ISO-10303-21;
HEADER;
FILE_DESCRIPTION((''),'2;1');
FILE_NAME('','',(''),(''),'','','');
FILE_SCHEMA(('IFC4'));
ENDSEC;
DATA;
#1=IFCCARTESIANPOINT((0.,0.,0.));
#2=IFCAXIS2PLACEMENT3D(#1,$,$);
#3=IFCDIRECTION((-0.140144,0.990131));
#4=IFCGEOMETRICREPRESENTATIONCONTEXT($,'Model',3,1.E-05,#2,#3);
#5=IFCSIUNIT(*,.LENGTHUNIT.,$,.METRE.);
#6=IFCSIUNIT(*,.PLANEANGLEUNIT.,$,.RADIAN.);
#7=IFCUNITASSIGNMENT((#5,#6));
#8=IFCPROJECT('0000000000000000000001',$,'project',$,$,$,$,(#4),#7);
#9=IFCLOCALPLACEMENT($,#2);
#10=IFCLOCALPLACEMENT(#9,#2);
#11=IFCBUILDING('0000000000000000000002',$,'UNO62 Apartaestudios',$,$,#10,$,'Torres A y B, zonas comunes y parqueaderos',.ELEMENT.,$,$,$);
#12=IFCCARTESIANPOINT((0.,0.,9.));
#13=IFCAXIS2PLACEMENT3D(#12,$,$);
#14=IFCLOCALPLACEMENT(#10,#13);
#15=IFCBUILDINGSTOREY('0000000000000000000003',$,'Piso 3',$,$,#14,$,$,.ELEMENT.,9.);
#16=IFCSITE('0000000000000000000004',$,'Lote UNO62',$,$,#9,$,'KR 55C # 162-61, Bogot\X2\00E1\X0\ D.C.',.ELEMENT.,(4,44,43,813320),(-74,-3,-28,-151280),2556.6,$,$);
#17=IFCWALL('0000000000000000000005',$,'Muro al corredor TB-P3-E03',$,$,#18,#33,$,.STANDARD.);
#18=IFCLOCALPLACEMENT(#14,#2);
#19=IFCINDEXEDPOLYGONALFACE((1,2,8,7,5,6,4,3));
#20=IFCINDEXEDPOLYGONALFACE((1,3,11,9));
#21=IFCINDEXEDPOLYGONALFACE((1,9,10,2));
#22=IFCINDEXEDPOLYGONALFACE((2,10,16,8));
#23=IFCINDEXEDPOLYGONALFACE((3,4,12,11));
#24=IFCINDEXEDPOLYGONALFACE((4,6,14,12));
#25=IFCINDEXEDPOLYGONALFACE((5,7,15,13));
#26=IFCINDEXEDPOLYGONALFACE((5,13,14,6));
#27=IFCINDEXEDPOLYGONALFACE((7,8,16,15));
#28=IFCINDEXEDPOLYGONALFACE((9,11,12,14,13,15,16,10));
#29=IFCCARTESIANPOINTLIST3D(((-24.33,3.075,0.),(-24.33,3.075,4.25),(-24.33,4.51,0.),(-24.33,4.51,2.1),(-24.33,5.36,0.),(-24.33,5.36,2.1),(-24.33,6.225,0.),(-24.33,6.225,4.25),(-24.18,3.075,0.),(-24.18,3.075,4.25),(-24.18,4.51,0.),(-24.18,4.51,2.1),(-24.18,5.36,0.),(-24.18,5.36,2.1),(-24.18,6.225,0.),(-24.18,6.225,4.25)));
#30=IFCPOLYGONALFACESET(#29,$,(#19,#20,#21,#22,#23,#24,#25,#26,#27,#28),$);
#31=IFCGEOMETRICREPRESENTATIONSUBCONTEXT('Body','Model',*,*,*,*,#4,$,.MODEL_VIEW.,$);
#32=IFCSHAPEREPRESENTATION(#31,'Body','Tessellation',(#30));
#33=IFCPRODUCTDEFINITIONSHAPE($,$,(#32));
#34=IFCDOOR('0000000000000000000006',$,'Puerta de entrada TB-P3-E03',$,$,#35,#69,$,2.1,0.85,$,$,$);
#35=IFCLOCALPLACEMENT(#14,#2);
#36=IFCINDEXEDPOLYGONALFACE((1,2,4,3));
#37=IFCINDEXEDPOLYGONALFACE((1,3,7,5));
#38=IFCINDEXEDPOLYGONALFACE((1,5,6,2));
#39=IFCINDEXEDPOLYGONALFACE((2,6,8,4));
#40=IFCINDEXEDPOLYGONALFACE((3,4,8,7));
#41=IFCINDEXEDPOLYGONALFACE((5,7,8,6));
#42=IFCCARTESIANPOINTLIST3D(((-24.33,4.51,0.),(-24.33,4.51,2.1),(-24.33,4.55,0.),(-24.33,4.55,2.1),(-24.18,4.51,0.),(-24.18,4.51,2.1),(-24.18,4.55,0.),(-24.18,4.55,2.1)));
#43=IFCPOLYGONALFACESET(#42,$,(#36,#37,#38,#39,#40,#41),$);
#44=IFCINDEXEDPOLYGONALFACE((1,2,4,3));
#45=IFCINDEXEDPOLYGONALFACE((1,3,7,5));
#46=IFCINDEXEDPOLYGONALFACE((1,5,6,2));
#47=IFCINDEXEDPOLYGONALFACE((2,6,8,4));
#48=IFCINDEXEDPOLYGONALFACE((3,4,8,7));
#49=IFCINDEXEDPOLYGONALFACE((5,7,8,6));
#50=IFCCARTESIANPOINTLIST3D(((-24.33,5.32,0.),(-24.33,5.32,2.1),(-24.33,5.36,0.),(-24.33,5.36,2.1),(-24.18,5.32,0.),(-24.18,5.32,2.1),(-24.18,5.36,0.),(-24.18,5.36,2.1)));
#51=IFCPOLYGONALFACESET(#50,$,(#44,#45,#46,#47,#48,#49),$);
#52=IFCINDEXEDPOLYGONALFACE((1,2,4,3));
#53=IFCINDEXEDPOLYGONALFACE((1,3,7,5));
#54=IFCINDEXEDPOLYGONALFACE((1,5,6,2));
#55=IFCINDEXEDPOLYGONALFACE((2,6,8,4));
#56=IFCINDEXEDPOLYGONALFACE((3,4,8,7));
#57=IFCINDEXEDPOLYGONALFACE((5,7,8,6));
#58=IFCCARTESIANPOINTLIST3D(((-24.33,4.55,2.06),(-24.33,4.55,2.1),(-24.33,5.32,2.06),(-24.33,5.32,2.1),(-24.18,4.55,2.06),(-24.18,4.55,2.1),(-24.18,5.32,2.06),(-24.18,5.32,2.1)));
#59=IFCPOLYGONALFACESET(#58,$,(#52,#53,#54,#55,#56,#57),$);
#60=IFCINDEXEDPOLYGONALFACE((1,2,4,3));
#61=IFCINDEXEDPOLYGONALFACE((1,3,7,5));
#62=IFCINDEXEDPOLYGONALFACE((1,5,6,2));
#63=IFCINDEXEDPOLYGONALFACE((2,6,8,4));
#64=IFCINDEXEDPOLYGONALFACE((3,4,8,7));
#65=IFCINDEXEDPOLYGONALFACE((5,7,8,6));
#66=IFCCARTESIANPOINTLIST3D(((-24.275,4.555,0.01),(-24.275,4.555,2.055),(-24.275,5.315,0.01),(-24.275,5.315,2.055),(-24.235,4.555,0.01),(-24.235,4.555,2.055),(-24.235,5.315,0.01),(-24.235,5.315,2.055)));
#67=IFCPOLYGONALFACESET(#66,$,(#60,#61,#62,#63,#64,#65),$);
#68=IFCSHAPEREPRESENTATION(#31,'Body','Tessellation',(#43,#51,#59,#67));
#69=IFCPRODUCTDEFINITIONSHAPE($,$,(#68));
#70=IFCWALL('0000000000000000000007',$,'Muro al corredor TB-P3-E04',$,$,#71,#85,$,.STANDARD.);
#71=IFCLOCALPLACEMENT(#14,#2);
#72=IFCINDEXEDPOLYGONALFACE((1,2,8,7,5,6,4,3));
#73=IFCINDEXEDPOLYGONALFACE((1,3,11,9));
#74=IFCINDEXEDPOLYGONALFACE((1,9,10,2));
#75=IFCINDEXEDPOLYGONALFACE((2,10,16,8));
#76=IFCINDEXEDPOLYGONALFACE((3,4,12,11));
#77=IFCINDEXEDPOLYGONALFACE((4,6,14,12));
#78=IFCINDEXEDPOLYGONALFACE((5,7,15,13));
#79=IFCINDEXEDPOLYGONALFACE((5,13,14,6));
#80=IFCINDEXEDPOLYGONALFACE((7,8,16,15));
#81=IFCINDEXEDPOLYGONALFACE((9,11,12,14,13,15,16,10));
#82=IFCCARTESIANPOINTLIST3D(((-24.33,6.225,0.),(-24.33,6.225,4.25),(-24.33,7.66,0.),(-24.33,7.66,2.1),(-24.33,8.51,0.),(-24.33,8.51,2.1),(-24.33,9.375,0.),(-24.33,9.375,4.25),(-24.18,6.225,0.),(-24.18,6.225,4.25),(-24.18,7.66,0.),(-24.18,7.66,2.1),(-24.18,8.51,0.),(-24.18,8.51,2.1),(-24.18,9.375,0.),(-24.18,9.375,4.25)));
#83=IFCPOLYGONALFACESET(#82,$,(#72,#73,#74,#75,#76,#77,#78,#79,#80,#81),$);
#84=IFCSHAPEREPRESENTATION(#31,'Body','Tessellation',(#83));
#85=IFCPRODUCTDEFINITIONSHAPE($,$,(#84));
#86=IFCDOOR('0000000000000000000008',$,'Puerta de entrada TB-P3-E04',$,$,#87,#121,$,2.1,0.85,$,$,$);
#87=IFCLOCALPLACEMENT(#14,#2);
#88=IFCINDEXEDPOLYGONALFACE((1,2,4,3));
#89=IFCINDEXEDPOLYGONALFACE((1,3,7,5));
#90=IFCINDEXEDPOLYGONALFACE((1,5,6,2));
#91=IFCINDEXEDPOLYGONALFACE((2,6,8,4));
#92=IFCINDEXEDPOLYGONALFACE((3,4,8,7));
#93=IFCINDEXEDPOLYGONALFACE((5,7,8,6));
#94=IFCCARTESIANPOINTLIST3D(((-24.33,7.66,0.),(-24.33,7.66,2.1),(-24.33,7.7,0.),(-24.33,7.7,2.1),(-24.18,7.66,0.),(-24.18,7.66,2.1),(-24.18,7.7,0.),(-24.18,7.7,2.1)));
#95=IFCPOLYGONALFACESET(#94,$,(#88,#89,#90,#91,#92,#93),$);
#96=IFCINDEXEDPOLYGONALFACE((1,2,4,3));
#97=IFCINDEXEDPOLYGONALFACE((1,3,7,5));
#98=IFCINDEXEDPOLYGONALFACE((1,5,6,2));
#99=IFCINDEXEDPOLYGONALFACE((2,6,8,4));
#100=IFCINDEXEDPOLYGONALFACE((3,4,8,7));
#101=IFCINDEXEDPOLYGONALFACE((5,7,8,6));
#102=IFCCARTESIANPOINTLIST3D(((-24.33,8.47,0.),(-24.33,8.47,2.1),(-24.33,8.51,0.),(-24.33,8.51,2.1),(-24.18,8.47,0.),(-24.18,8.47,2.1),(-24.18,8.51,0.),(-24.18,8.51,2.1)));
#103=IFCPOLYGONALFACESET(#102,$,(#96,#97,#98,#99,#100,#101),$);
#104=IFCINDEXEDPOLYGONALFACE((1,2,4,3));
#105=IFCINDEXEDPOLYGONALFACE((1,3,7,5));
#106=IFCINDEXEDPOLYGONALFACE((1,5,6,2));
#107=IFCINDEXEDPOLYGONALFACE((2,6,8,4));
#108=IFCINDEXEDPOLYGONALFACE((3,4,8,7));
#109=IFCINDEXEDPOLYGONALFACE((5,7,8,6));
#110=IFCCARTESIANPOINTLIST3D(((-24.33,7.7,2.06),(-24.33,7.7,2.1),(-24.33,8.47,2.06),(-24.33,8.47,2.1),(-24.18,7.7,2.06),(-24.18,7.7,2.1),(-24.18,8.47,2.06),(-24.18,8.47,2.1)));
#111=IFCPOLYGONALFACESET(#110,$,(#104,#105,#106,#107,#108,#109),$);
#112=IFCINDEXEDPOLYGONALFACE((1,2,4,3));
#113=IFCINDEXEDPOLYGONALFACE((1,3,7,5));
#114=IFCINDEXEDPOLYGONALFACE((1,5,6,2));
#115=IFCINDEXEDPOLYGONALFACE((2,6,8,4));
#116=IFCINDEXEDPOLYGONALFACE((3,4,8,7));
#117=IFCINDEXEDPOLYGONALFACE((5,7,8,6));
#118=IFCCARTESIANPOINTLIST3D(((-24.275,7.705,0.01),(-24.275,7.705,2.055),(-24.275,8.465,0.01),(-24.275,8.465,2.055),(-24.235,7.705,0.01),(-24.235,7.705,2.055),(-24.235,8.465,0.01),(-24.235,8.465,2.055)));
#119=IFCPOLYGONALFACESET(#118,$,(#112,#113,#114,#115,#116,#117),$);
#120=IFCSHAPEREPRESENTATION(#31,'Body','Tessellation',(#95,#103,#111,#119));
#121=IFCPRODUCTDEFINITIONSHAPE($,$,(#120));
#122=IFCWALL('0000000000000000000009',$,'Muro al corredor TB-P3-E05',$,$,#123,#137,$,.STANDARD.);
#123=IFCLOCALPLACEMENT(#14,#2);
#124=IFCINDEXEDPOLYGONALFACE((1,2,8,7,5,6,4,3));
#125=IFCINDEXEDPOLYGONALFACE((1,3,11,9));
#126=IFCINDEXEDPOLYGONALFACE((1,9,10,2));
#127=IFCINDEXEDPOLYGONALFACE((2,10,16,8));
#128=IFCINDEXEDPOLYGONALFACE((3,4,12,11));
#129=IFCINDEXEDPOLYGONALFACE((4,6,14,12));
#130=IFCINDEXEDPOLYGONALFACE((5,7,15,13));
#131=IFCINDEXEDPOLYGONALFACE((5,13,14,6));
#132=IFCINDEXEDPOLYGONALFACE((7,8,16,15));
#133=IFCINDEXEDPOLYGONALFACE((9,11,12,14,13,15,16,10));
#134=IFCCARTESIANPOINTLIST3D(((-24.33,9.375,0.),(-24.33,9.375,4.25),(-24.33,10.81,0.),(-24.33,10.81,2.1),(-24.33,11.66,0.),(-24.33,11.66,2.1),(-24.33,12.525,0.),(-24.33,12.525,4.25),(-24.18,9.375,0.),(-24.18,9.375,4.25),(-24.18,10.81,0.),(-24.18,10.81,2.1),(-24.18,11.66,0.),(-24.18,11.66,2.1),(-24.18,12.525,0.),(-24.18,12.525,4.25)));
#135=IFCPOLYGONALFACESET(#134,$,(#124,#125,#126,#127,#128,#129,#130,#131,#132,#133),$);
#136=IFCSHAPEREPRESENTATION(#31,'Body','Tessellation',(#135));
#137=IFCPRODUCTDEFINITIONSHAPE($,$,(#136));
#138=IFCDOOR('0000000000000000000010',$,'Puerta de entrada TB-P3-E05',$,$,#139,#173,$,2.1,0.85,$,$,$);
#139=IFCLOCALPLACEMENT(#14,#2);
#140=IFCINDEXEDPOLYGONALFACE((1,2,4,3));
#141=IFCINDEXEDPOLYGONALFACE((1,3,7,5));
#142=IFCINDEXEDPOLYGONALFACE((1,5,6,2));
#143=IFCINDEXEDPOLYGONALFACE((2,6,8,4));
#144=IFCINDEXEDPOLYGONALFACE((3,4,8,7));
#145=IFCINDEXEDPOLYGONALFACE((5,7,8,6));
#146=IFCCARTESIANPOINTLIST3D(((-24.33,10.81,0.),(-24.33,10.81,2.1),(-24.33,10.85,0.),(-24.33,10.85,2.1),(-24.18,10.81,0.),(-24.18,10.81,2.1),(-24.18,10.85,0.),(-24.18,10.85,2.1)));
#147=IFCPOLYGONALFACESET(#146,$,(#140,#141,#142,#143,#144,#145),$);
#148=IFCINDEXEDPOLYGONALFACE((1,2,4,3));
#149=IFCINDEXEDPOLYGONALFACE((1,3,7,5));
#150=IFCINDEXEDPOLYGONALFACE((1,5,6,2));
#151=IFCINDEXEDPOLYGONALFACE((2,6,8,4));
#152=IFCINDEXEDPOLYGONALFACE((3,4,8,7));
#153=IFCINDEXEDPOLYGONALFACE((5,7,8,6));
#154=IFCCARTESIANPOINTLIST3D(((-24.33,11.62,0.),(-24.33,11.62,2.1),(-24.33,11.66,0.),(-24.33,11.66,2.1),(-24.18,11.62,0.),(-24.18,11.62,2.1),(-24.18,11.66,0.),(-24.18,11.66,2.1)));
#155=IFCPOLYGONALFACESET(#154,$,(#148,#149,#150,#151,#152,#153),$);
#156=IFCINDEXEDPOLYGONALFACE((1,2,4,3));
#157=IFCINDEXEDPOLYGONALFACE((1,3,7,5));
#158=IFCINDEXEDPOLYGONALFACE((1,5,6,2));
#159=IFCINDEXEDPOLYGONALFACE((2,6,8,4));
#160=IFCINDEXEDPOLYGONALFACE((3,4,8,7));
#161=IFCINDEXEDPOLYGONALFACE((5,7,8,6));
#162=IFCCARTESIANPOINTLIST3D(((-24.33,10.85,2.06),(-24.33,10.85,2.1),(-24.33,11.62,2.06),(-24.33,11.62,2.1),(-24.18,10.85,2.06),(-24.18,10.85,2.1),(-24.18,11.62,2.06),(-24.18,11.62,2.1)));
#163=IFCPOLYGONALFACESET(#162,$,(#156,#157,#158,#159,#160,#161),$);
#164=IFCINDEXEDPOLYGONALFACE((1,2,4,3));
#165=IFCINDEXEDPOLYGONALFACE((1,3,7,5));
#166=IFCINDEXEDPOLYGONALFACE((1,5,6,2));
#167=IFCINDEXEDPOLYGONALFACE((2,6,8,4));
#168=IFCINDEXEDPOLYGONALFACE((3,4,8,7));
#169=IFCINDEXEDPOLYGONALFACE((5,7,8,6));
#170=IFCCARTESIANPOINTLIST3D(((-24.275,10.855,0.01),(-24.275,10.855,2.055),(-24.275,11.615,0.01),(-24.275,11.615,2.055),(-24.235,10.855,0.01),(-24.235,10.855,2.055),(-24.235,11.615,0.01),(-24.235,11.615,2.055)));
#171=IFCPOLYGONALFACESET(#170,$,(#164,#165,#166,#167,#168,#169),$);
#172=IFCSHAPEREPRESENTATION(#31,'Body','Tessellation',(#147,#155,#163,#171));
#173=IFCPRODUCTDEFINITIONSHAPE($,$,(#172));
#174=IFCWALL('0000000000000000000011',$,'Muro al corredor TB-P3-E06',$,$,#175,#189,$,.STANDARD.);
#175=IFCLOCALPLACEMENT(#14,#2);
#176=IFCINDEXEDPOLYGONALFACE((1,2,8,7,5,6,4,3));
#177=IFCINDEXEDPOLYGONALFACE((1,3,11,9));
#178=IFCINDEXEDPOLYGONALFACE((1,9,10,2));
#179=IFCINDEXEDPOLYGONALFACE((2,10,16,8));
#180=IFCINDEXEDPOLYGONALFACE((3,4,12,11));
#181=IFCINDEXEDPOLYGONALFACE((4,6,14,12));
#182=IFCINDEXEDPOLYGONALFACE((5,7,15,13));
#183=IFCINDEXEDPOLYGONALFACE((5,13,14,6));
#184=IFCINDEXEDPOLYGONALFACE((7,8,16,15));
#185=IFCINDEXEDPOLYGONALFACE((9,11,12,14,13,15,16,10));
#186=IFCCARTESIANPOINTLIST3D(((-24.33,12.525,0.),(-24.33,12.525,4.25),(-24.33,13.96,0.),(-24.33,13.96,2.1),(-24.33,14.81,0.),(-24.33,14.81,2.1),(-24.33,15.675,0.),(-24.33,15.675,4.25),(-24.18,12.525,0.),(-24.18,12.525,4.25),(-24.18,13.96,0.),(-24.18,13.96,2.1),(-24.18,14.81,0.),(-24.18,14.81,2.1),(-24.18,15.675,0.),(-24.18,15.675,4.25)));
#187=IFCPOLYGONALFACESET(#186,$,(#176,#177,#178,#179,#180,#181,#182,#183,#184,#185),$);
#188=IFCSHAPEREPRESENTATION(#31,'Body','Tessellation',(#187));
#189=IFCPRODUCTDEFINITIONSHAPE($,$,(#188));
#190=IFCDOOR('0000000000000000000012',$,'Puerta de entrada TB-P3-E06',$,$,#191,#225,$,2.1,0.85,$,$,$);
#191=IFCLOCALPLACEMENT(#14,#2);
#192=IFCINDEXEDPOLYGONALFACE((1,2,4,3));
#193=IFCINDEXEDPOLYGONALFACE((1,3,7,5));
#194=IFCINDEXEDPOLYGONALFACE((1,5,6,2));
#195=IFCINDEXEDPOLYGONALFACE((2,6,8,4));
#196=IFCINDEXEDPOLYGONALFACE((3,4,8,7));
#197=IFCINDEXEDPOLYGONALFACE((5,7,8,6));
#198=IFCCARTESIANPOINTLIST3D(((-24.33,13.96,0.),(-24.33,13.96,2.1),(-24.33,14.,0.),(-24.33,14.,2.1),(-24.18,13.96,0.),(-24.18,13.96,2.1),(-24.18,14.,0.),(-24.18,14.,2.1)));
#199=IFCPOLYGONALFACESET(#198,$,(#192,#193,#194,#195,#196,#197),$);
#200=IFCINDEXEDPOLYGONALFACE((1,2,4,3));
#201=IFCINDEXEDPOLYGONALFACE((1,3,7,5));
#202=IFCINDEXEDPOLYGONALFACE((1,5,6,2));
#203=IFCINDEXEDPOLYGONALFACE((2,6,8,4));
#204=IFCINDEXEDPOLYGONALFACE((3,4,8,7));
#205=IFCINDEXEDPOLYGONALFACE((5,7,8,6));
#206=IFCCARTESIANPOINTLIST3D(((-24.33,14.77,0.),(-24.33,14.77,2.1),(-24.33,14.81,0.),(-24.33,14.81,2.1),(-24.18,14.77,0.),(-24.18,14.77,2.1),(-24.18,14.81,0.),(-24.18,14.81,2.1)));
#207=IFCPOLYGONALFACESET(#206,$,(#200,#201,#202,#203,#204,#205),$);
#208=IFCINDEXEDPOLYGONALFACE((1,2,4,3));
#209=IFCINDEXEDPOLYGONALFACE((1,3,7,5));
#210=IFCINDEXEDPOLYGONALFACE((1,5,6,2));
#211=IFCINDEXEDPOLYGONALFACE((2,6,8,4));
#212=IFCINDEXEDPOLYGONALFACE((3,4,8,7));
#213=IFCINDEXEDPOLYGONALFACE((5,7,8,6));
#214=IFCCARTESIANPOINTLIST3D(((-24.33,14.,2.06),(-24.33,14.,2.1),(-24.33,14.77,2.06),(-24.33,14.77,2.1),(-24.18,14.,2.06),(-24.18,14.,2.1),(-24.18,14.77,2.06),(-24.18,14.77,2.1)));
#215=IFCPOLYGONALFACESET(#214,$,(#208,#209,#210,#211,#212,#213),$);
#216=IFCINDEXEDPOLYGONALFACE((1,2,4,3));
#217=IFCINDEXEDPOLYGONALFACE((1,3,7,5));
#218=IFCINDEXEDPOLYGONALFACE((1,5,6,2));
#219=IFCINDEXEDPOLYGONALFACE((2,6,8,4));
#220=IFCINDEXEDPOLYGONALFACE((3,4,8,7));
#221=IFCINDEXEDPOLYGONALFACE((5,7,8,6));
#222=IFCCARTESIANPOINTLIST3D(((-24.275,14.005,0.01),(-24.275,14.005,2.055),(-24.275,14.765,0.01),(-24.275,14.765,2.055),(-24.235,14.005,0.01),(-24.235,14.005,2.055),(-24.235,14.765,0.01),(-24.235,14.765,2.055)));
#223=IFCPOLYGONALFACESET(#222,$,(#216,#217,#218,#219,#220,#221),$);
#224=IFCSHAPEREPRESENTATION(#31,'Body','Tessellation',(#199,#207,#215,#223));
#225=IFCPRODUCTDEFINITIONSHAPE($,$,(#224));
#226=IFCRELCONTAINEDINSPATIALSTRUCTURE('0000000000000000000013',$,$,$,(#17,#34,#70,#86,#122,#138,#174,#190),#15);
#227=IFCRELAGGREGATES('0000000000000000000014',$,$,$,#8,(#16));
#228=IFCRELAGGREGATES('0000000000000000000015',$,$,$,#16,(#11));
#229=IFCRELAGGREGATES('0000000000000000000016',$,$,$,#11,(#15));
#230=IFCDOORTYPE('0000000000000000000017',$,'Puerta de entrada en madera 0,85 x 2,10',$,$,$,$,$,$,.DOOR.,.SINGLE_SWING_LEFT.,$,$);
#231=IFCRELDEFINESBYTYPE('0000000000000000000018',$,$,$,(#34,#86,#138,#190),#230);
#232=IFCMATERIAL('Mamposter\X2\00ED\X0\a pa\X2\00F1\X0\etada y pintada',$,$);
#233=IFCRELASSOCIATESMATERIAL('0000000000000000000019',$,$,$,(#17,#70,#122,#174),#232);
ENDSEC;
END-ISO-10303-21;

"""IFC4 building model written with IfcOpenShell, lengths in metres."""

from ifc_helpers import new_model, si_unit, direction, frame, frame_2d, origin, place, context, subcontext, project, spatial, rectangle, extrude, source, transform, mapped, material, type_object, type_shapes, element, fill, save


model = new_model("IFC4")

# Units and contexts
model_context = context("Model", 3, precision=1e-05, world=origin(), true_north=direction((-0.140144, 0.990131)))
body_context = subcontext(model_context, "Body", "Model", "MODEL_VIEW")
ifc_project = project(units=[si_unit("LENGTHUNIT", "METRE"), si_unit("PLANEANGLEUNIT", "RADIAN")], contexts=[model_context])

# Site, building, storey
site_placement = place(None, origin())
site = spatial("IfcSite", under=ifc_project, at=site_placement, Name="Lote UNO62", LongName="KR 55C # 162-61, Bogotá D.C.", CompositionType="ELEMENT", RefLatitude=(4, 44, 43, 813320), RefLongitude=(-74, -3, -28, -151280), RefElevation=2556.6)
building_placement = place(site_placement, origin())
building = spatial("IfcBuilding", under=site, at=building_placement, Name="UNO62 Apartaestudios", LongName="Torres A y B, zonas comunes y parqueaderos", CompositionType="ELEMENT")
storey_placement = place(building_placement, frame((0.0, 0.0, 9.0)))
storey = spatial("IfcBuildingStorey", under=building, at=storey_placement, Name="Piso 3", CompositionType="ELEMENT", Elevation=9.0)

# Shared definitions
placement_1 = place(storey_placement, frame((-24.18, 3.15, 0.0)))
placement_2 = place(storey_placement, frame((-24.18, 6.3, 0.0)))
placement_3 = place(storey_placement, frame((-24.18, 9.45, 0.0)))
placement_4 = place(storey_placement, frame((-24.18, 12.6, 0.0)))

# Walls, openings, doors
ifc_material_1 = material(Name="Mampostería pañetada y pintada")
door_type_1 = type_object("IfcDoorType", Name="Puerta de entrada en madera 0,85 x 2,10", OperationType="SINGLE_SWING_LEFT", PredefinedType="DOOR")
shared_shape_1 = source(origin(), body_context, "Body", "SweptSolid", [
    extrude(rectangle(XDim=0.15, YDim=0.04, at=frame_2d((-0.075, 1.38))), origin(), (0.0, 0.0, 1.0), 2.1),
    extrude(rectangle(XDim=0.15, YDim=0.04, at=frame_2d((-0.075, 2.19))), origin(), (0.0, 0.0, 1.0), 2.1),
    extrude(rectangle(XDim=0.15, YDim=0.77, at=frame_2d((-0.075, 1.785))), frame((0.0, 0.0, 2.06)), (0.0, 0.0, 1.0), 0.04),
    extrude(rectangle(XDim=0.04, YDim=0.76, at=frame_2d((-0.075, 1.785))), frame((0.0, 0.0, 0.01)), (0.0, 0.0, 1.0), 2.045),
])
type_shapes(door_type_1, [shared_shape_1])
wall_1_placement = place(storey_placement, origin())
wall_1 = element("IfcWall", 1, at=wall_1_placement, inside=storey, material=ifc_material_1, Name="Muro al corredor TB-P3-E03", PredefinedType="STANDARD", context=body_context, shape_type="SweptSolid", body=[
    extrude(rectangle(XDim=0.15, YDim=3.15, at=frame_2d((-24.255, 4.65))), origin(), (0.0, 0.0, 1.0), 4.25),
])
opening_1_placement = place(wall_1_placement, origin())
opening_1 = element("IfcOpeningElement", 2, at=opening_1_placement, cuts=wall_1, PredefinedType="OPENING", context=body_context, shape_type="SweptSolid", body=[
    extrude(rectangle(XDim=0.25, YDim=0.85, at=frame_2d((-24.255, 4.935))), origin(), (0.0, 0.0, 1.0), 2.1),
])
door_1_placement = place(placement_1, origin())
door_1 = element("IfcDoor", 3, at=door_1_placement, inside=storey, type_object=door_type_1, Name="Puerta de entrada TB-P3-E03", OverallHeight=2.1, OverallWidth=0.85, context=body_context, shape_type="MappedRepresentation", body=[
    mapped(shared_shape_1, transform((0.0, 0.0, 0.0))),
])
fill(opening_1, door_1)
wall_2_placement = place(storey_placement, origin())
wall_2 = element("IfcWall", 4, at=wall_2_placement, inside=storey, material=ifc_material_1, Name="Muro al corredor TB-P3-E04", PredefinedType="STANDARD", context=body_context, shape_type="SweptSolid", body=[
    extrude(rectangle(XDim=0.15, YDim=3.15, at=frame_2d((-24.255, 7.8))), origin(), (0.0, 0.0, 1.0), 4.25),
])
opening_2_placement = place(wall_2_placement, origin())
opening_2 = element("IfcOpeningElement", 5, at=opening_2_placement, cuts=wall_2, PredefinedType="OPENING", context=body_context, shape_type="SweptSolid", body=[
    extrude(rectangle(XDim=0.25, YDim=0.85, at=frame_2d((-24.255, 8.085))), origin(), (0.0, 0.0, 1.0), 2.1),
])
door_2_placement = place(placement_2, origin())
door_2 = element("IfcDoor", 6, at=door_2_placement, inside=storey, type_object=door_type_1, Name="Puerta de entrada TB-P3-E04", OverallHeight=2.1, OverallWidth=0.85, context=body_context, shape_type="MappedRepresentation", body=[
    mapped(shared_shape_1, transform((0.0, 0.0, 0.0))),
])
fill(opening_2, door_2)
wall_3_placement = place(storey_placement, origin())
wall_3 = element("IfcWall", 7, at=wall_3_placement, inside=storey, material=ifc_material_1, Name="Muro al corredor TB-P3-E05", PredefinedType="STANDARD", context=body_context, shape_type="SweptSolid", body=[
    extrude(rectangle(XDim=0.15, YDim=3.15, at=frame_2d((-24.255, 10.95))), origin(), (0.0, 0.0, 1.0), 4.25),
])
opening_3_placement = place(wall_3_placement, origin())
opening_3 = element("IfcOpeningElement", 8, at=opening_3_placement, cuts=wall_3, PredefinedType="OPENING", context=body_context, shape_type="SweptSolid", body=[
    extrude(rectangle(XDim=0.25, YDim=0.85, at=frame_2d((-24.255, 11.235))), origin(), (0.0, 0.0, 1.0), 2.1),
])
door_3_placement = place(placement_3, origin())
door_3 = element("IfcDoor", 9, at=door_3_placement, inside=storey, type_object=door_type_1, Name="Puerta de entrada TB-P3-E05", OverallHeight=2.1, OverallWidth=0.85, context=body_context, shape_type="MappedRepresentation", body=[
    mapped(shared_shape_1, transform((0.0, 0.0, 0.0))),
])
fill(opening_3, door_3)
wall_4_placement = place(storey_placement, origin())
wall_4 = element("IfcWall", 10, at=wall_4_placement, inside=storey, material=ifc_material_1, Name="Muro al corredor TB-P3-E06", PredefinedType="STANDARD", context=body_context, shape_type="SweptSolid", body=[
    extrude(rectangle(XDim=0.15, YDim=3.15, at=frame_2d((-24.255, 14.1))), origin(), (0.0, 0.0, 1.0), 4.25),
])
opening_4_placement = place(wall_4_placement, origin())
opening_4 = element("IfcOpeningElement", 11, at=opening_4_placement, cuts=wall_4, PredefinedType="OPENING", context=body_context, shape_type="SweptSolid", body=[
    extrude(rectangle(XDim=0.25, YDim=0.85, at=frame_2d((-24.255, 14.385))), origin(), (0.0, 0.0, 1.0), 2.1),
])
door_4_placement = place(placement_4, origin())
door_4 = element("IfcDoor", 12, at=door_4_placement, inside=storey, type_object=door_type_1, Name="Puerta de entrada TB-P3-E06", OverallHeight=2.1, OverallWidth=0.85, context=body_context, shape_type="MappedRepresentation", body=[
    mapped(shared_shape_1, transform((0.0, 0.0, 0.0))),
])
fill(opening_4, door_4)

save(model, "model.ifc")
